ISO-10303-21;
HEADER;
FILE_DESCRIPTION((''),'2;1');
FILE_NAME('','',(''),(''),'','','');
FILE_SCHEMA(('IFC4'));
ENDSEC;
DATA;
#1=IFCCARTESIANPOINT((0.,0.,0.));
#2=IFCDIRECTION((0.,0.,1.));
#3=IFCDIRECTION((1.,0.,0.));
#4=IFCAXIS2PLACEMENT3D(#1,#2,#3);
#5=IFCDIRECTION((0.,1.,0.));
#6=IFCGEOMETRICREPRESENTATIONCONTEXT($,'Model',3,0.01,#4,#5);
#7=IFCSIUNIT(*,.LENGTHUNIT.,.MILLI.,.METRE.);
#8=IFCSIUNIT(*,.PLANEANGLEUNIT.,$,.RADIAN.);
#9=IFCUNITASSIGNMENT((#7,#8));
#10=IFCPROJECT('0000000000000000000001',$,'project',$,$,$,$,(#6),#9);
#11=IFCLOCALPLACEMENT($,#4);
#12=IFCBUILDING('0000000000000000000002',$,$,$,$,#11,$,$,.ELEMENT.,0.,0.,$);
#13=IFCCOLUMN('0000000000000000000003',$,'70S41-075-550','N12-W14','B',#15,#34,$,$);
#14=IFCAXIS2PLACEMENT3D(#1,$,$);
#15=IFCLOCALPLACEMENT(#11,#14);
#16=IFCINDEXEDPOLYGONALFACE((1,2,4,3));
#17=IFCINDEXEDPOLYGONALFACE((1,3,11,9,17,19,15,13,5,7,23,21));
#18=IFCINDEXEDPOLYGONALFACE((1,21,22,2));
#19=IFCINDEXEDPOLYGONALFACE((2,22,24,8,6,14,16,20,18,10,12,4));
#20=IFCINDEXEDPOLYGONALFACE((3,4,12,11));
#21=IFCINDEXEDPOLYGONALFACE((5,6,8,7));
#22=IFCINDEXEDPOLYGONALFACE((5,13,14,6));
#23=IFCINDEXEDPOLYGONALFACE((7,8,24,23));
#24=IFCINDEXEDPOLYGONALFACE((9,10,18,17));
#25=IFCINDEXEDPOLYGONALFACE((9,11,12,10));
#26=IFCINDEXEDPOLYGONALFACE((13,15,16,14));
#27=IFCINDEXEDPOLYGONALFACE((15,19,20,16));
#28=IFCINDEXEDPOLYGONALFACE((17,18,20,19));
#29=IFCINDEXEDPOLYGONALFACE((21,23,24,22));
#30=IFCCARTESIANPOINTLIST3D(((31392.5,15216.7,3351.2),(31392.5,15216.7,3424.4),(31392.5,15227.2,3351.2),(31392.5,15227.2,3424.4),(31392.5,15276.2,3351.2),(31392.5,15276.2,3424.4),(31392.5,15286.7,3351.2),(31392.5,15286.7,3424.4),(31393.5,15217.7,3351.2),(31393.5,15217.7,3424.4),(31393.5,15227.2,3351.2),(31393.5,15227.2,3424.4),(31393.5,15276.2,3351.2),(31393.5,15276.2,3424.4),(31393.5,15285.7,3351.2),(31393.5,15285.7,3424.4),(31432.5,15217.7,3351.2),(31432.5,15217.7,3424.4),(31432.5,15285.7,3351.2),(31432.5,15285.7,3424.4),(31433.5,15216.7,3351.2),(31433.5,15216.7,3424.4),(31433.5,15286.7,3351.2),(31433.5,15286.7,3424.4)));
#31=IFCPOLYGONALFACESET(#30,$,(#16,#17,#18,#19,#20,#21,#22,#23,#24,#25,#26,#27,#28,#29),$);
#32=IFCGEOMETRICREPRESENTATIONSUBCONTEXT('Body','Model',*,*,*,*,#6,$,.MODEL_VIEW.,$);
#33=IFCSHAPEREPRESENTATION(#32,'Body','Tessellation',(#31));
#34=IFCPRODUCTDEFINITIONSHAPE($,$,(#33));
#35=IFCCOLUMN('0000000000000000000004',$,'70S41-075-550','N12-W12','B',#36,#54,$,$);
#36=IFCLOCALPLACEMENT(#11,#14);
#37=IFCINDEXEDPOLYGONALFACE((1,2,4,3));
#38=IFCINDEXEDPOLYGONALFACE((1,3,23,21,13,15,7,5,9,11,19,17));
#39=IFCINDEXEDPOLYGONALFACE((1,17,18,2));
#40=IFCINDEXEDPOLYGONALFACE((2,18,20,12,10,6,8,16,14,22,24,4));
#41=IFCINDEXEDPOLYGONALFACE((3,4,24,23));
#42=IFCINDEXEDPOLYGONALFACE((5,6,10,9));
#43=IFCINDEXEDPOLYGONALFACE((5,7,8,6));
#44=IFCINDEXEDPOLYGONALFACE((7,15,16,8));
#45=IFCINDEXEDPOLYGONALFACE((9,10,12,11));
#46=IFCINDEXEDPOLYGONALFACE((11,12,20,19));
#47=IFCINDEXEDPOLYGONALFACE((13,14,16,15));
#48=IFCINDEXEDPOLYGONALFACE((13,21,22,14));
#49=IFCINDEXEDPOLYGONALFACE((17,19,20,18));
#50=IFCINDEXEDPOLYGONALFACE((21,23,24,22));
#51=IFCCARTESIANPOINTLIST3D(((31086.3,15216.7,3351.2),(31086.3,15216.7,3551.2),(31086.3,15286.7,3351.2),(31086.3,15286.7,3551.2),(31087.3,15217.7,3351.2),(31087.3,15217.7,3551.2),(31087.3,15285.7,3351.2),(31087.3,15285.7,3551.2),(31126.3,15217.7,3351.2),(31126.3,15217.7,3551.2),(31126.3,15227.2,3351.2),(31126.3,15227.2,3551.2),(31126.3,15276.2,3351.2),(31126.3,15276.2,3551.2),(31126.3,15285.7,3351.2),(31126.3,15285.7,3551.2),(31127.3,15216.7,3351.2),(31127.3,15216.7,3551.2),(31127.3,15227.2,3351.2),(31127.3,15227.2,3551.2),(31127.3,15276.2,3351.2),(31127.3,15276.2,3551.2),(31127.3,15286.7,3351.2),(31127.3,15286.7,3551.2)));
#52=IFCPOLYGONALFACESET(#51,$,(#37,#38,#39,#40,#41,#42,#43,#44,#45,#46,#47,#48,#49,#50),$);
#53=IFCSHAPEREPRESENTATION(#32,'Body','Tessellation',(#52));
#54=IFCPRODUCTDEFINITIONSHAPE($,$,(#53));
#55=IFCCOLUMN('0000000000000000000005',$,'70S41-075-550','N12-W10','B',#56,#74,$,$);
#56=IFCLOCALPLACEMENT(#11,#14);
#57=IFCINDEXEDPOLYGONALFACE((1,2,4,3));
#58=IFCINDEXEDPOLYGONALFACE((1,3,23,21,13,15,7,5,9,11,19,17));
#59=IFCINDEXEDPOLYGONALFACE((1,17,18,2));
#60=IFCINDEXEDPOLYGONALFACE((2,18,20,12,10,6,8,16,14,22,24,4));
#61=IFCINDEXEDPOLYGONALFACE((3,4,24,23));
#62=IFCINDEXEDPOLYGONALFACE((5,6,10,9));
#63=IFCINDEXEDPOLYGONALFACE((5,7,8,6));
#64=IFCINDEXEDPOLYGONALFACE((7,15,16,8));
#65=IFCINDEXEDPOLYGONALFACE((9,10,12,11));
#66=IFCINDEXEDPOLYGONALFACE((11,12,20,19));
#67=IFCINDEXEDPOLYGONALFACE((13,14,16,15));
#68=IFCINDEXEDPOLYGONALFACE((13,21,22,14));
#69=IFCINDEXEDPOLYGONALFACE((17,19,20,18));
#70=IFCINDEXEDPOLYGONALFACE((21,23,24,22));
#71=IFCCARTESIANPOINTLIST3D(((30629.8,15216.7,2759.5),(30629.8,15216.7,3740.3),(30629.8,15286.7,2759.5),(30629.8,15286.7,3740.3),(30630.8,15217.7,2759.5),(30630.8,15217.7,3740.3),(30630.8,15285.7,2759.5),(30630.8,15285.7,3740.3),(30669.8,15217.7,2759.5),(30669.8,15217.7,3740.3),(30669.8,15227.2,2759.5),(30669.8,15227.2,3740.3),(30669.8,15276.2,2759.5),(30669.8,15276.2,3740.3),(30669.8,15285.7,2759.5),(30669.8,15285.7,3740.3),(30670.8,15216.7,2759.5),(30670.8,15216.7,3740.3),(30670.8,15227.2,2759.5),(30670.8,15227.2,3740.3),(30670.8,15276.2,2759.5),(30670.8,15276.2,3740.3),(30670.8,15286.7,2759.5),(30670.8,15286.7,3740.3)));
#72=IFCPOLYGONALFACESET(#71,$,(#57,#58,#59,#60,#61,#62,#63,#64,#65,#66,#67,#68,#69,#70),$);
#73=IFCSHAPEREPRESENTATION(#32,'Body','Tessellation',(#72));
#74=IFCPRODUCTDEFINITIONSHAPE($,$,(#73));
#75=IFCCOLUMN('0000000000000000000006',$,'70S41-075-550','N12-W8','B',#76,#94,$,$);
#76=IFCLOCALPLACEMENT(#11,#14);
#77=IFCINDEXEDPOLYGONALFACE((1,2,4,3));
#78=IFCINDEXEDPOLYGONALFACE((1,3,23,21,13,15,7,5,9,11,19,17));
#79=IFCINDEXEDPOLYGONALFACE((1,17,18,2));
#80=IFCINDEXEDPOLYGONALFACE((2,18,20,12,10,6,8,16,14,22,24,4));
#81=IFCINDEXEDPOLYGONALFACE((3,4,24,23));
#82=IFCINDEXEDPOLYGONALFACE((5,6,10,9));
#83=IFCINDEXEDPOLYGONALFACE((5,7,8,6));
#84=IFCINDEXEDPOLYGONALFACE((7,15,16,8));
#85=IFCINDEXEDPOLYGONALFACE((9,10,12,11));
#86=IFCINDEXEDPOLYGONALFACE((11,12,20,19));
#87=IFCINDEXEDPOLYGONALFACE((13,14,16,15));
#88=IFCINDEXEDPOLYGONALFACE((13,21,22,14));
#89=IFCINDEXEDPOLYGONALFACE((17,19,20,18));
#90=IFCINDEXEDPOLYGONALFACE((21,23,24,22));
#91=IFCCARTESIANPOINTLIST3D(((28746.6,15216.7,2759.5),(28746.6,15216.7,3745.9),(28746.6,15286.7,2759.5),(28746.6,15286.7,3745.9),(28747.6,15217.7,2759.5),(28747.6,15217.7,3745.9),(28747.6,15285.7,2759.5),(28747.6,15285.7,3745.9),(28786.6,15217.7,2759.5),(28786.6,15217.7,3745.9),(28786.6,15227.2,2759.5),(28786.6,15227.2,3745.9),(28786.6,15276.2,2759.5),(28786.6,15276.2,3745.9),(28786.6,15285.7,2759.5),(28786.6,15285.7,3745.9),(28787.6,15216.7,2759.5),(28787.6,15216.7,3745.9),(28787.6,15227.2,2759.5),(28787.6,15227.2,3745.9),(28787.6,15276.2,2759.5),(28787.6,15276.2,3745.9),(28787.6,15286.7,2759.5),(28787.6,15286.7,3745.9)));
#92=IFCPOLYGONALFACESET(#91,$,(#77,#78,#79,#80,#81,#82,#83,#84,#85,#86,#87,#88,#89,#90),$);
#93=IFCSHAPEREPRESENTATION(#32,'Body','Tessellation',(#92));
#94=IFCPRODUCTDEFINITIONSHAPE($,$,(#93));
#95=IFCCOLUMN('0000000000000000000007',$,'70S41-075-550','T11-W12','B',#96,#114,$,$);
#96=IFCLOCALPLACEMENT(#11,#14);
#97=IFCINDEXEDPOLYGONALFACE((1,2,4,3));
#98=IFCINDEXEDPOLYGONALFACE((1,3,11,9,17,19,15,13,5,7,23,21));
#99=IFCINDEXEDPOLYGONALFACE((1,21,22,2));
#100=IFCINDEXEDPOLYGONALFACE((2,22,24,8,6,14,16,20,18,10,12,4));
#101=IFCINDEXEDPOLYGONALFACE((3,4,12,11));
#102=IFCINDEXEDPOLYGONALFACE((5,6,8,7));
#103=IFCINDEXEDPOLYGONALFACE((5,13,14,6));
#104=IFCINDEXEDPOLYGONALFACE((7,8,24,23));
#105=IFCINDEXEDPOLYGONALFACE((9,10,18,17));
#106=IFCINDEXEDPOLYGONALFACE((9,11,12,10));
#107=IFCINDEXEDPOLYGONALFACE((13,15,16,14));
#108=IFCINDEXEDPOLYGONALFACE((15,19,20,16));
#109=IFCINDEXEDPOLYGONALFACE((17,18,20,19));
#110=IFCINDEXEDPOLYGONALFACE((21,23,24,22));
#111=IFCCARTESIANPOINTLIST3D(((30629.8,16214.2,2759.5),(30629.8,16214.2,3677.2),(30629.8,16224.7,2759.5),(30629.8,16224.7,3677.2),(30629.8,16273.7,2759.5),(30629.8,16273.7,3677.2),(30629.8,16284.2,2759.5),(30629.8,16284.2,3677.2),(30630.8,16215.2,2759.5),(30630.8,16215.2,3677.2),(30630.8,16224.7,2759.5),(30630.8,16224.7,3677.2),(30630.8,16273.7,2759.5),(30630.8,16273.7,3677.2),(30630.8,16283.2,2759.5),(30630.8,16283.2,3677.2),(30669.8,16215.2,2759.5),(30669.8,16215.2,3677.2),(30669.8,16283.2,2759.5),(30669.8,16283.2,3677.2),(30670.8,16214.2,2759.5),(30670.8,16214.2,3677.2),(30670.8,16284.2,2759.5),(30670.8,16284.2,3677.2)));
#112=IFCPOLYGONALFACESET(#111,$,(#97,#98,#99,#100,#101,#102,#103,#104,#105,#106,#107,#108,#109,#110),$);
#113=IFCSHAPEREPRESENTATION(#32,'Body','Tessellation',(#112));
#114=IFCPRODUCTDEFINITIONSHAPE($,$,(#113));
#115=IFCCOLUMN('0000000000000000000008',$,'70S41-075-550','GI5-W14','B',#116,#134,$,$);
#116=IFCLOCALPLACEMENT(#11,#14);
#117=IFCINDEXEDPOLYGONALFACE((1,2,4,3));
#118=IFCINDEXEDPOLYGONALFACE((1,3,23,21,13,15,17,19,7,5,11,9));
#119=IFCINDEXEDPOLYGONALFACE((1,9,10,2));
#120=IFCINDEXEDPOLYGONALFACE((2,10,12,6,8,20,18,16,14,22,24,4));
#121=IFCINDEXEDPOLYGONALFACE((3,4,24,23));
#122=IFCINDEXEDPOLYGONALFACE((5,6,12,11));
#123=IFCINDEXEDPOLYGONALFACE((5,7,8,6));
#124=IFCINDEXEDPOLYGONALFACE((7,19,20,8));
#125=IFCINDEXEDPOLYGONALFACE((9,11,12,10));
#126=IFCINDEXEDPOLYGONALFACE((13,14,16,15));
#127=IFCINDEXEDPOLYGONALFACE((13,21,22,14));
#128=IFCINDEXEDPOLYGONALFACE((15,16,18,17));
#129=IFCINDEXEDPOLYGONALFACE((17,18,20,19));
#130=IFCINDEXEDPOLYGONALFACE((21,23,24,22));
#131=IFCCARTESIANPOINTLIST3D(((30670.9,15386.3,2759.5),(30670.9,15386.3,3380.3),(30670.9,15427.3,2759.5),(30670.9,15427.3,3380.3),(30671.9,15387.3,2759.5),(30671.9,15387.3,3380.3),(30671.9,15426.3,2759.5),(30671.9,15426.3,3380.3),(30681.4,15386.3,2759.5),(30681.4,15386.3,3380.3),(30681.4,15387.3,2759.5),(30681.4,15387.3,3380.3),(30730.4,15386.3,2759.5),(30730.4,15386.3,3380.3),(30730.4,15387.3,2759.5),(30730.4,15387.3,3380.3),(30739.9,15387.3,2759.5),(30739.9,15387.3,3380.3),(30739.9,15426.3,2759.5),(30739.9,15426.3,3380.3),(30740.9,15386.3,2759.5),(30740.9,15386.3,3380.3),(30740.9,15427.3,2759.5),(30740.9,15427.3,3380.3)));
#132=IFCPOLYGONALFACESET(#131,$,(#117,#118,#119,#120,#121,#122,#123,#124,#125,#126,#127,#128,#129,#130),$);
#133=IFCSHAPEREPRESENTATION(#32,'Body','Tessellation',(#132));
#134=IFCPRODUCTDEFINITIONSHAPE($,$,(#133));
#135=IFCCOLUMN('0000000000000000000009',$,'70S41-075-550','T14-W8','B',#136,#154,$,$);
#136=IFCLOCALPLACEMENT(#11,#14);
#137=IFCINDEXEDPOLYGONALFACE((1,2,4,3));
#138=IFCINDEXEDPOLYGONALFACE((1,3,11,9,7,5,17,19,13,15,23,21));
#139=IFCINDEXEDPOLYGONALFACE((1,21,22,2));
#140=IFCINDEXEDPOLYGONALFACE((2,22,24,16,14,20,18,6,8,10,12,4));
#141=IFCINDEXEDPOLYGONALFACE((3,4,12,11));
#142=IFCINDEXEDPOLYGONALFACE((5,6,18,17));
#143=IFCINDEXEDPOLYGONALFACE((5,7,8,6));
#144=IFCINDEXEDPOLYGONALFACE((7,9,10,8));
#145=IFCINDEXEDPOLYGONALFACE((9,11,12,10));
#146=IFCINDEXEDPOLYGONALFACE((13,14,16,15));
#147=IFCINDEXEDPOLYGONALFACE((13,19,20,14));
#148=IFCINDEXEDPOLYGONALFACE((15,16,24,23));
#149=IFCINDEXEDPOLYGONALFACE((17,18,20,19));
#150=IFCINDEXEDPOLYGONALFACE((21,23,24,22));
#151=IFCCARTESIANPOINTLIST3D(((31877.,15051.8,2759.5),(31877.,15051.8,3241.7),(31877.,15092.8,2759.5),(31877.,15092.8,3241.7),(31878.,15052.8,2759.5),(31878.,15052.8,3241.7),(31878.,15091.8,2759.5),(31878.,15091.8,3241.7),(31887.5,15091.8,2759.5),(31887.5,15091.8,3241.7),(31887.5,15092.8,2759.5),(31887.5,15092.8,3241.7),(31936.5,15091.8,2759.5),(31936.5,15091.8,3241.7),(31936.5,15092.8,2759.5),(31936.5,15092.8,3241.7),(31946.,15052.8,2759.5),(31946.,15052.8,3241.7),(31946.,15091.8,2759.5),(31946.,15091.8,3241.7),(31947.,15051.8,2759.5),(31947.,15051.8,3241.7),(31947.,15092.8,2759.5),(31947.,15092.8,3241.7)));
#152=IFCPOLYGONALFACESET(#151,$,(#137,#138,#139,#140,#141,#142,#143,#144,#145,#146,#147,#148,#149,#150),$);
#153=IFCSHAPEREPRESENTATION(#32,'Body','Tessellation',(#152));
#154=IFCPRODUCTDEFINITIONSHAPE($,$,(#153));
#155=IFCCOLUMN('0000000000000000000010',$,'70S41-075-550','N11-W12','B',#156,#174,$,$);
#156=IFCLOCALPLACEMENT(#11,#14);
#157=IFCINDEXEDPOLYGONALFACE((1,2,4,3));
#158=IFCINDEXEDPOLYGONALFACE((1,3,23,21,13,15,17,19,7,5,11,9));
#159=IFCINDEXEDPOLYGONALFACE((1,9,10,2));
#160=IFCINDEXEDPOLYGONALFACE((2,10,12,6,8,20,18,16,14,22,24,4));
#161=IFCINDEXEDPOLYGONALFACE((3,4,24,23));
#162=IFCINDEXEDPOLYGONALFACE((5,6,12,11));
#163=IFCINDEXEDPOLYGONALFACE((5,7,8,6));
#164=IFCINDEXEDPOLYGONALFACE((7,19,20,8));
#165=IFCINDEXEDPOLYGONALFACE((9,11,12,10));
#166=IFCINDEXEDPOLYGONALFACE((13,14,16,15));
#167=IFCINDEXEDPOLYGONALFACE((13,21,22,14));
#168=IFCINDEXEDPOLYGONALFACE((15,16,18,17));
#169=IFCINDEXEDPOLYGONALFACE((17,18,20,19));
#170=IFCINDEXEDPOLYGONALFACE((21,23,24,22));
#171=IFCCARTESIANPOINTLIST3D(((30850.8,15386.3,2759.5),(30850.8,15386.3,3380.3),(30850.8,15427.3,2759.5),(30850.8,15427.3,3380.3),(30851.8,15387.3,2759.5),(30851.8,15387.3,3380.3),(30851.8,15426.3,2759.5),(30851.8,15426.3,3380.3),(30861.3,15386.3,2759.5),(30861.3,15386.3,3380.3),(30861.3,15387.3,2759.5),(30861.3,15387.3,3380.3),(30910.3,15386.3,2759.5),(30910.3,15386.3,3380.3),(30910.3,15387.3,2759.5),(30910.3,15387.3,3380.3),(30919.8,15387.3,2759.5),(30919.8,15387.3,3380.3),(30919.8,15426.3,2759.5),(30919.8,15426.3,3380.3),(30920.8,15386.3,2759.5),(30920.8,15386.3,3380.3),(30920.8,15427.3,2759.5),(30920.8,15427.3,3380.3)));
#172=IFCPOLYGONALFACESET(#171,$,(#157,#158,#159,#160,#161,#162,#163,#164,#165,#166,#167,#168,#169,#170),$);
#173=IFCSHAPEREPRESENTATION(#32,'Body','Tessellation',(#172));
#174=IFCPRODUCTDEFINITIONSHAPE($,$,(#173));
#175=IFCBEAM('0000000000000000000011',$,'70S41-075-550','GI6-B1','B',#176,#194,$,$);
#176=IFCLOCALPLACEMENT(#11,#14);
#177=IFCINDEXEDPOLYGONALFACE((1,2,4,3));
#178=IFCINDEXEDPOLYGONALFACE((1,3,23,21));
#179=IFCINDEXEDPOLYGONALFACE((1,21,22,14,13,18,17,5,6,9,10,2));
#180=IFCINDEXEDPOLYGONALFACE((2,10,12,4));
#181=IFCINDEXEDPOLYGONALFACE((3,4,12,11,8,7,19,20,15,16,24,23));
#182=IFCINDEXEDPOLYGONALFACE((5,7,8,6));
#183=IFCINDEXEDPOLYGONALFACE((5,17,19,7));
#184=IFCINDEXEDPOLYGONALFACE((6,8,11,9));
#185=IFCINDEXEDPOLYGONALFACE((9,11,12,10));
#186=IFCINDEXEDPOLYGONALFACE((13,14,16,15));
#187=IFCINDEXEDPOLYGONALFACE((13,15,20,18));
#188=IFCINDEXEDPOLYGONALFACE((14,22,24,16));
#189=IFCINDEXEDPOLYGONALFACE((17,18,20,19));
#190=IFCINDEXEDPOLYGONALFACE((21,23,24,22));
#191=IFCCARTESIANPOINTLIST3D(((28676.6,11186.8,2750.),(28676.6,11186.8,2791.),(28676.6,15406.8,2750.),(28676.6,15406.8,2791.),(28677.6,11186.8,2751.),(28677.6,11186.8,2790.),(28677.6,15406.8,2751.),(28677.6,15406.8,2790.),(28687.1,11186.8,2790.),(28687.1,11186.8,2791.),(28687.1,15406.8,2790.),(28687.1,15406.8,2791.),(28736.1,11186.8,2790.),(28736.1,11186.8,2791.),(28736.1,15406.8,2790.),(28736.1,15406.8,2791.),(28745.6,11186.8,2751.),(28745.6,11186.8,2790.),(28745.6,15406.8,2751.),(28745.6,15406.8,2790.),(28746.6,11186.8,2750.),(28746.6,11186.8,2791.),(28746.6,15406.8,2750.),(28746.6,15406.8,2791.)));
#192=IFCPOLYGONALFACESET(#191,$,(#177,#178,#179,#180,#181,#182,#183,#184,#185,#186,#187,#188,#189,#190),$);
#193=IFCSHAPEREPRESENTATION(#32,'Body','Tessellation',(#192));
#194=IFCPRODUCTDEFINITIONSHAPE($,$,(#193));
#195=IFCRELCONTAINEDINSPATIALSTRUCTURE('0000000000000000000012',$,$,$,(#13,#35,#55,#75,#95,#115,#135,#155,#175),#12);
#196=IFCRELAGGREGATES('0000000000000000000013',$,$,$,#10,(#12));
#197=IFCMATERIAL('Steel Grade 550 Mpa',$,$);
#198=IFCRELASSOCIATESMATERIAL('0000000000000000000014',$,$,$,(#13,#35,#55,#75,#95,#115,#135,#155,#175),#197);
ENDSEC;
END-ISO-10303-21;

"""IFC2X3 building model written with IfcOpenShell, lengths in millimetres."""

from ifc_helpers import new_model, si_unit, direction, frame, origin, origin_with_axes, origin_2d_with_axis, place, context, subcontext, project, spatial, c_section, extrude, source, transform, mapped, material, element, save


model = new_model("IFC2X3")

# Units and contexts
model_context = context("Model", 3, precision=0.01, world=origin_with_axes(), true_north=direction((0.0, 1.0, 0.0)))
body_context = subcontext(model_context, "Body", "Model", "MODEL_VIEW")
ifc_project = project(units=[si_unit("LENGTHUNIT", "METRE", prefix="MILLI"), si_unit("PLANEANGLEUNIT", "RADIAN")], contexts=[model_context])

# Building
building_placement = place(None, origin_with_axes())
building = spatial("IfcBuilding", under=ifc_project, at=building_placement, CompositionType="ELEMENT", ElevationOfRefHeight=0.0, ElevationOfTerrain=0.0)

# Columns
ifc_material = material(Name="Steel Grade 550 Mpa")
shared_shape_1 = source(origin(), body_context, "Body", "SweptSolid", [
    extrude(c_section(Depth=70.0, Width=41.0, WallThickness=1.0, Girth=10.5, at=origin_2d_with_axis()), origin_with_axes(), (0.0, 0.0, 1.0), 73.2),
])
column_1_placement = place(None, frame((31413.0, 15251.7, 3351.2), z_axis=(0.0, 0.0, 1.0), x_axis=(-1.0, 0.0, 0.0)))
element("IfcColumn", 1, at=column_1_placement, inside=building, material=ifc_material, Name="70S41-075-550", Description="N12-W14", ObjectType="B", context=body_context, shape_type="MappedRepresentation", body=[
    mapped(shared_shape_1, transform((0.0, 0.0, 0.0), scale=1.0)),
])
shared_shape_2 = source(origin(), body_context, "Body", "SweptSolid", [
    extrude(c_section(Depth=70.0, Width=41.0, WallThickness=1.0, Girth=10.5, at=origin_2d_with_axis()), origin_with_axes(), (0.0, 0.0, 1.0), 200.0),
])
column_2_placement = place(None, frame((31106.8, 15251.7, 3551.2), z_axis=(0.0, 0.0, -1.0), x_axis=(1.0, 0.0, 0.0)))
element("IfcColumn", 2, at=column_2_placement, inside=building, material=ifc_material, Name="70S41-075-550", Description="N12-W12", ObjectType="B", context=body_context, shape_type="MappedRepresentation", body=[
    mapped(shared_shape_2, transform((0.0, 0.0, 0.0), scale=1.0)),
])
shared_shape_3 = source(origin(), body_context, "Body", "SweptSolid", [
    extrude(c_section(Depth=70.0, Width=41.0, WallThickness=1.0, Girth=10.5, at=origin_2d_with_axis()), origin_with_axes(), (0.0, 0.0, 1.0), 980.8),
])
column_3_placement = place(None, frame((30650.3, 15251.7, 3740.3), z_axis=(0.0, 0.0, -1.0), x_axis=(1.0, 0.0, 0.0)))
element("IfcColumn", 3, at=column_3_placement, inside=building, material=ifc_material, Name="70S41-075-550", Description="N12-W10", ObjectType="B", context=body_context, shape_type="MappedRepresentation", body=[
    mapped(shared_shape_3, transform((0.0, 0.0, 0.0), scale=1.0)),
])
shared_shape_4 = source(origin(), body_context, "Body", "SweptSolid", [
    extrude(c_section(Depth=70.0, Width=41.0, WallThickness=1.0, Girth=10.5, at=origin_2d_with_axis()), origin_with_axes(), (0.0, 0.0, 1.0), 986.4),
])
column_4_placement = place(None, frame((28767.1, 15251.7, 3745.9), z_axis=(0.0, 0.0, -1.0), x_axis=(1.0, 0.0, 0.0)))
element("IfcColumn", 4, at=column_4_placement, inside=building, material=ifc_material, Name="70S41-075-550", Description="N12-W8", ObjectType="B", context=body_context, shape_type="MappedRepresentation", body=[
    mapped(shared_shape_4, transform((0.0, 0.0, 0.0), scale=1.0)),
])
shared_shape_5 = source(origin(), body_context, "Body", "SweptSolid", [
    extrude(c_section(Depth=70.0, Width=41.0, WallThickness=1.0, Girth=10.5, at=origin_2d_with_axis()), origin_with_axes(), (0.0, 0.0, 1.0), 917.7),
])
column_5_placement = place(None, frame((30650.3, 16249.2, 2759.5), z_axis=(0.0, 0.0, 1.0), x_axis=(-1.0, 0.0, 0.0)))
element("IfcColumn", 5, at=column_5_placement, inside=building, material=ifc_material, Name="70S41-075-550", Description="T11-W12", ObjectType="B", context=body_context, shape_type="MappedRepresentation", body=[
    mapped(shared_shape_5, transform((0.0, 0.0, 0.0), scale=1.0)),
])
shared_shape_6 = source(origin(), body_context, "Body", "SweptSolid", [
    extrude(c_section(Depth=70.0, Width=41.0, WallThickness=1.0, Girth=10.5, at=origin_2d_with_axis()), origin_with_axes(), (0.0, 0.0, 1.0), 620.8),
])
column_6_placement = place(None, frame((30705.9, 15406.8, 3380.3), z_axis=(0.0, 0.0, -1.0), x_axis=(0.0, -1.0, 0.0)))
element("IfcColumn", 6, at=column_6_placement, inside=building, material=ifc_material, Name="70S41-075-550", Description="GI5-W14", ObjectType="B", context=body_context, shape_type="MappedRepresentation", body=[
    mapped(shared_shape_6, transform((0.0, 0.0, 0.0), scale=1.0)),
])
shared_shape_7 = source(origin(), body_context, "Body", "SweptSolid", [
    extrude(c_section(Depth=70.0, Width=41.0, WallThickness=1.0, Girth=10.5, at=origin_2d_with_axis()), origin_with_axes(), (0.0, 0.0, 1.0), 482.2),
])
column_7_placement = place(None, frame((31912.0, 15072.3, 2759.5), z_axis=(0.0, 0.0, 1.0), x_axis=(0.0, 1.0, 0.0)))
element("IfcColumn", 7, at=column_7_placement, inside=building, material=ifc_material, Name="70S41-075-550", Description="T14-W8", ObjectType="B", context=body_context, shape_type="MappedRepresentation", body=[
    mapped(shared_shape_7, transform((0.0, 0.0, 0.0), scale=1.0)),
])
shared_shape_8 = source(origin(), body_context, "Body", "SweptSolid", [
    extrude(c_section(Depth=70.0, Width=41.0, WallThickness=1.0, Girth=10.5, at=origin_2d_with_axis()), origin_with_axes(), (0.0, 0.0, 1.0), 620.8),
])
column_8_placement = place(None, frame((30885.8, 15406.8, 3380.3), z_axis=(0.0, 0.0, -1.0), x_axis=(0.0, -1.0, 0.0)))
element("IfcColumn", 8, at=column_8_placement, inside=building, material=ifc_material, Name="70S41-075-550", Description="N11-W12", ObjectType="B", context=body_context, shape_type="MappedRepresentation", body=[
    mapped(shared_shape_8, transform((0.0, 0.0, 0.0), scale=1.0)),
])

# Beam
shared_shape_9 = source(origin(), body_context, "Body", "SweptSolid", [
    extrude(c_section(Depth=70.0, Width=41.0, WallThickness=1.0, Girth=10.5, at=origin_2d_with_axis()), origin_with_axes(), (0.0, 0.0, 1.0), 4220.0),
])
beam_1_placement = place(None, frame((28711.6, 15406.8, 2770.5), z_axis=(0.0, -1.0, 0.0), x_axis=(0.0, 0.0, 1.0)))
element("IfcBeam", 9, at=beam_1_placement, inside=building, material=ifc_material, Name="70S41-075-550", Description="GI6-B1", ObjectType="B", context=body_context, shape_type="MappedRepresentation", body=[
    mapped(shared_shape_9, transform((0.0, 0.0, 0.0), scale=1.0)),
])

save(model, "model.ifc")
